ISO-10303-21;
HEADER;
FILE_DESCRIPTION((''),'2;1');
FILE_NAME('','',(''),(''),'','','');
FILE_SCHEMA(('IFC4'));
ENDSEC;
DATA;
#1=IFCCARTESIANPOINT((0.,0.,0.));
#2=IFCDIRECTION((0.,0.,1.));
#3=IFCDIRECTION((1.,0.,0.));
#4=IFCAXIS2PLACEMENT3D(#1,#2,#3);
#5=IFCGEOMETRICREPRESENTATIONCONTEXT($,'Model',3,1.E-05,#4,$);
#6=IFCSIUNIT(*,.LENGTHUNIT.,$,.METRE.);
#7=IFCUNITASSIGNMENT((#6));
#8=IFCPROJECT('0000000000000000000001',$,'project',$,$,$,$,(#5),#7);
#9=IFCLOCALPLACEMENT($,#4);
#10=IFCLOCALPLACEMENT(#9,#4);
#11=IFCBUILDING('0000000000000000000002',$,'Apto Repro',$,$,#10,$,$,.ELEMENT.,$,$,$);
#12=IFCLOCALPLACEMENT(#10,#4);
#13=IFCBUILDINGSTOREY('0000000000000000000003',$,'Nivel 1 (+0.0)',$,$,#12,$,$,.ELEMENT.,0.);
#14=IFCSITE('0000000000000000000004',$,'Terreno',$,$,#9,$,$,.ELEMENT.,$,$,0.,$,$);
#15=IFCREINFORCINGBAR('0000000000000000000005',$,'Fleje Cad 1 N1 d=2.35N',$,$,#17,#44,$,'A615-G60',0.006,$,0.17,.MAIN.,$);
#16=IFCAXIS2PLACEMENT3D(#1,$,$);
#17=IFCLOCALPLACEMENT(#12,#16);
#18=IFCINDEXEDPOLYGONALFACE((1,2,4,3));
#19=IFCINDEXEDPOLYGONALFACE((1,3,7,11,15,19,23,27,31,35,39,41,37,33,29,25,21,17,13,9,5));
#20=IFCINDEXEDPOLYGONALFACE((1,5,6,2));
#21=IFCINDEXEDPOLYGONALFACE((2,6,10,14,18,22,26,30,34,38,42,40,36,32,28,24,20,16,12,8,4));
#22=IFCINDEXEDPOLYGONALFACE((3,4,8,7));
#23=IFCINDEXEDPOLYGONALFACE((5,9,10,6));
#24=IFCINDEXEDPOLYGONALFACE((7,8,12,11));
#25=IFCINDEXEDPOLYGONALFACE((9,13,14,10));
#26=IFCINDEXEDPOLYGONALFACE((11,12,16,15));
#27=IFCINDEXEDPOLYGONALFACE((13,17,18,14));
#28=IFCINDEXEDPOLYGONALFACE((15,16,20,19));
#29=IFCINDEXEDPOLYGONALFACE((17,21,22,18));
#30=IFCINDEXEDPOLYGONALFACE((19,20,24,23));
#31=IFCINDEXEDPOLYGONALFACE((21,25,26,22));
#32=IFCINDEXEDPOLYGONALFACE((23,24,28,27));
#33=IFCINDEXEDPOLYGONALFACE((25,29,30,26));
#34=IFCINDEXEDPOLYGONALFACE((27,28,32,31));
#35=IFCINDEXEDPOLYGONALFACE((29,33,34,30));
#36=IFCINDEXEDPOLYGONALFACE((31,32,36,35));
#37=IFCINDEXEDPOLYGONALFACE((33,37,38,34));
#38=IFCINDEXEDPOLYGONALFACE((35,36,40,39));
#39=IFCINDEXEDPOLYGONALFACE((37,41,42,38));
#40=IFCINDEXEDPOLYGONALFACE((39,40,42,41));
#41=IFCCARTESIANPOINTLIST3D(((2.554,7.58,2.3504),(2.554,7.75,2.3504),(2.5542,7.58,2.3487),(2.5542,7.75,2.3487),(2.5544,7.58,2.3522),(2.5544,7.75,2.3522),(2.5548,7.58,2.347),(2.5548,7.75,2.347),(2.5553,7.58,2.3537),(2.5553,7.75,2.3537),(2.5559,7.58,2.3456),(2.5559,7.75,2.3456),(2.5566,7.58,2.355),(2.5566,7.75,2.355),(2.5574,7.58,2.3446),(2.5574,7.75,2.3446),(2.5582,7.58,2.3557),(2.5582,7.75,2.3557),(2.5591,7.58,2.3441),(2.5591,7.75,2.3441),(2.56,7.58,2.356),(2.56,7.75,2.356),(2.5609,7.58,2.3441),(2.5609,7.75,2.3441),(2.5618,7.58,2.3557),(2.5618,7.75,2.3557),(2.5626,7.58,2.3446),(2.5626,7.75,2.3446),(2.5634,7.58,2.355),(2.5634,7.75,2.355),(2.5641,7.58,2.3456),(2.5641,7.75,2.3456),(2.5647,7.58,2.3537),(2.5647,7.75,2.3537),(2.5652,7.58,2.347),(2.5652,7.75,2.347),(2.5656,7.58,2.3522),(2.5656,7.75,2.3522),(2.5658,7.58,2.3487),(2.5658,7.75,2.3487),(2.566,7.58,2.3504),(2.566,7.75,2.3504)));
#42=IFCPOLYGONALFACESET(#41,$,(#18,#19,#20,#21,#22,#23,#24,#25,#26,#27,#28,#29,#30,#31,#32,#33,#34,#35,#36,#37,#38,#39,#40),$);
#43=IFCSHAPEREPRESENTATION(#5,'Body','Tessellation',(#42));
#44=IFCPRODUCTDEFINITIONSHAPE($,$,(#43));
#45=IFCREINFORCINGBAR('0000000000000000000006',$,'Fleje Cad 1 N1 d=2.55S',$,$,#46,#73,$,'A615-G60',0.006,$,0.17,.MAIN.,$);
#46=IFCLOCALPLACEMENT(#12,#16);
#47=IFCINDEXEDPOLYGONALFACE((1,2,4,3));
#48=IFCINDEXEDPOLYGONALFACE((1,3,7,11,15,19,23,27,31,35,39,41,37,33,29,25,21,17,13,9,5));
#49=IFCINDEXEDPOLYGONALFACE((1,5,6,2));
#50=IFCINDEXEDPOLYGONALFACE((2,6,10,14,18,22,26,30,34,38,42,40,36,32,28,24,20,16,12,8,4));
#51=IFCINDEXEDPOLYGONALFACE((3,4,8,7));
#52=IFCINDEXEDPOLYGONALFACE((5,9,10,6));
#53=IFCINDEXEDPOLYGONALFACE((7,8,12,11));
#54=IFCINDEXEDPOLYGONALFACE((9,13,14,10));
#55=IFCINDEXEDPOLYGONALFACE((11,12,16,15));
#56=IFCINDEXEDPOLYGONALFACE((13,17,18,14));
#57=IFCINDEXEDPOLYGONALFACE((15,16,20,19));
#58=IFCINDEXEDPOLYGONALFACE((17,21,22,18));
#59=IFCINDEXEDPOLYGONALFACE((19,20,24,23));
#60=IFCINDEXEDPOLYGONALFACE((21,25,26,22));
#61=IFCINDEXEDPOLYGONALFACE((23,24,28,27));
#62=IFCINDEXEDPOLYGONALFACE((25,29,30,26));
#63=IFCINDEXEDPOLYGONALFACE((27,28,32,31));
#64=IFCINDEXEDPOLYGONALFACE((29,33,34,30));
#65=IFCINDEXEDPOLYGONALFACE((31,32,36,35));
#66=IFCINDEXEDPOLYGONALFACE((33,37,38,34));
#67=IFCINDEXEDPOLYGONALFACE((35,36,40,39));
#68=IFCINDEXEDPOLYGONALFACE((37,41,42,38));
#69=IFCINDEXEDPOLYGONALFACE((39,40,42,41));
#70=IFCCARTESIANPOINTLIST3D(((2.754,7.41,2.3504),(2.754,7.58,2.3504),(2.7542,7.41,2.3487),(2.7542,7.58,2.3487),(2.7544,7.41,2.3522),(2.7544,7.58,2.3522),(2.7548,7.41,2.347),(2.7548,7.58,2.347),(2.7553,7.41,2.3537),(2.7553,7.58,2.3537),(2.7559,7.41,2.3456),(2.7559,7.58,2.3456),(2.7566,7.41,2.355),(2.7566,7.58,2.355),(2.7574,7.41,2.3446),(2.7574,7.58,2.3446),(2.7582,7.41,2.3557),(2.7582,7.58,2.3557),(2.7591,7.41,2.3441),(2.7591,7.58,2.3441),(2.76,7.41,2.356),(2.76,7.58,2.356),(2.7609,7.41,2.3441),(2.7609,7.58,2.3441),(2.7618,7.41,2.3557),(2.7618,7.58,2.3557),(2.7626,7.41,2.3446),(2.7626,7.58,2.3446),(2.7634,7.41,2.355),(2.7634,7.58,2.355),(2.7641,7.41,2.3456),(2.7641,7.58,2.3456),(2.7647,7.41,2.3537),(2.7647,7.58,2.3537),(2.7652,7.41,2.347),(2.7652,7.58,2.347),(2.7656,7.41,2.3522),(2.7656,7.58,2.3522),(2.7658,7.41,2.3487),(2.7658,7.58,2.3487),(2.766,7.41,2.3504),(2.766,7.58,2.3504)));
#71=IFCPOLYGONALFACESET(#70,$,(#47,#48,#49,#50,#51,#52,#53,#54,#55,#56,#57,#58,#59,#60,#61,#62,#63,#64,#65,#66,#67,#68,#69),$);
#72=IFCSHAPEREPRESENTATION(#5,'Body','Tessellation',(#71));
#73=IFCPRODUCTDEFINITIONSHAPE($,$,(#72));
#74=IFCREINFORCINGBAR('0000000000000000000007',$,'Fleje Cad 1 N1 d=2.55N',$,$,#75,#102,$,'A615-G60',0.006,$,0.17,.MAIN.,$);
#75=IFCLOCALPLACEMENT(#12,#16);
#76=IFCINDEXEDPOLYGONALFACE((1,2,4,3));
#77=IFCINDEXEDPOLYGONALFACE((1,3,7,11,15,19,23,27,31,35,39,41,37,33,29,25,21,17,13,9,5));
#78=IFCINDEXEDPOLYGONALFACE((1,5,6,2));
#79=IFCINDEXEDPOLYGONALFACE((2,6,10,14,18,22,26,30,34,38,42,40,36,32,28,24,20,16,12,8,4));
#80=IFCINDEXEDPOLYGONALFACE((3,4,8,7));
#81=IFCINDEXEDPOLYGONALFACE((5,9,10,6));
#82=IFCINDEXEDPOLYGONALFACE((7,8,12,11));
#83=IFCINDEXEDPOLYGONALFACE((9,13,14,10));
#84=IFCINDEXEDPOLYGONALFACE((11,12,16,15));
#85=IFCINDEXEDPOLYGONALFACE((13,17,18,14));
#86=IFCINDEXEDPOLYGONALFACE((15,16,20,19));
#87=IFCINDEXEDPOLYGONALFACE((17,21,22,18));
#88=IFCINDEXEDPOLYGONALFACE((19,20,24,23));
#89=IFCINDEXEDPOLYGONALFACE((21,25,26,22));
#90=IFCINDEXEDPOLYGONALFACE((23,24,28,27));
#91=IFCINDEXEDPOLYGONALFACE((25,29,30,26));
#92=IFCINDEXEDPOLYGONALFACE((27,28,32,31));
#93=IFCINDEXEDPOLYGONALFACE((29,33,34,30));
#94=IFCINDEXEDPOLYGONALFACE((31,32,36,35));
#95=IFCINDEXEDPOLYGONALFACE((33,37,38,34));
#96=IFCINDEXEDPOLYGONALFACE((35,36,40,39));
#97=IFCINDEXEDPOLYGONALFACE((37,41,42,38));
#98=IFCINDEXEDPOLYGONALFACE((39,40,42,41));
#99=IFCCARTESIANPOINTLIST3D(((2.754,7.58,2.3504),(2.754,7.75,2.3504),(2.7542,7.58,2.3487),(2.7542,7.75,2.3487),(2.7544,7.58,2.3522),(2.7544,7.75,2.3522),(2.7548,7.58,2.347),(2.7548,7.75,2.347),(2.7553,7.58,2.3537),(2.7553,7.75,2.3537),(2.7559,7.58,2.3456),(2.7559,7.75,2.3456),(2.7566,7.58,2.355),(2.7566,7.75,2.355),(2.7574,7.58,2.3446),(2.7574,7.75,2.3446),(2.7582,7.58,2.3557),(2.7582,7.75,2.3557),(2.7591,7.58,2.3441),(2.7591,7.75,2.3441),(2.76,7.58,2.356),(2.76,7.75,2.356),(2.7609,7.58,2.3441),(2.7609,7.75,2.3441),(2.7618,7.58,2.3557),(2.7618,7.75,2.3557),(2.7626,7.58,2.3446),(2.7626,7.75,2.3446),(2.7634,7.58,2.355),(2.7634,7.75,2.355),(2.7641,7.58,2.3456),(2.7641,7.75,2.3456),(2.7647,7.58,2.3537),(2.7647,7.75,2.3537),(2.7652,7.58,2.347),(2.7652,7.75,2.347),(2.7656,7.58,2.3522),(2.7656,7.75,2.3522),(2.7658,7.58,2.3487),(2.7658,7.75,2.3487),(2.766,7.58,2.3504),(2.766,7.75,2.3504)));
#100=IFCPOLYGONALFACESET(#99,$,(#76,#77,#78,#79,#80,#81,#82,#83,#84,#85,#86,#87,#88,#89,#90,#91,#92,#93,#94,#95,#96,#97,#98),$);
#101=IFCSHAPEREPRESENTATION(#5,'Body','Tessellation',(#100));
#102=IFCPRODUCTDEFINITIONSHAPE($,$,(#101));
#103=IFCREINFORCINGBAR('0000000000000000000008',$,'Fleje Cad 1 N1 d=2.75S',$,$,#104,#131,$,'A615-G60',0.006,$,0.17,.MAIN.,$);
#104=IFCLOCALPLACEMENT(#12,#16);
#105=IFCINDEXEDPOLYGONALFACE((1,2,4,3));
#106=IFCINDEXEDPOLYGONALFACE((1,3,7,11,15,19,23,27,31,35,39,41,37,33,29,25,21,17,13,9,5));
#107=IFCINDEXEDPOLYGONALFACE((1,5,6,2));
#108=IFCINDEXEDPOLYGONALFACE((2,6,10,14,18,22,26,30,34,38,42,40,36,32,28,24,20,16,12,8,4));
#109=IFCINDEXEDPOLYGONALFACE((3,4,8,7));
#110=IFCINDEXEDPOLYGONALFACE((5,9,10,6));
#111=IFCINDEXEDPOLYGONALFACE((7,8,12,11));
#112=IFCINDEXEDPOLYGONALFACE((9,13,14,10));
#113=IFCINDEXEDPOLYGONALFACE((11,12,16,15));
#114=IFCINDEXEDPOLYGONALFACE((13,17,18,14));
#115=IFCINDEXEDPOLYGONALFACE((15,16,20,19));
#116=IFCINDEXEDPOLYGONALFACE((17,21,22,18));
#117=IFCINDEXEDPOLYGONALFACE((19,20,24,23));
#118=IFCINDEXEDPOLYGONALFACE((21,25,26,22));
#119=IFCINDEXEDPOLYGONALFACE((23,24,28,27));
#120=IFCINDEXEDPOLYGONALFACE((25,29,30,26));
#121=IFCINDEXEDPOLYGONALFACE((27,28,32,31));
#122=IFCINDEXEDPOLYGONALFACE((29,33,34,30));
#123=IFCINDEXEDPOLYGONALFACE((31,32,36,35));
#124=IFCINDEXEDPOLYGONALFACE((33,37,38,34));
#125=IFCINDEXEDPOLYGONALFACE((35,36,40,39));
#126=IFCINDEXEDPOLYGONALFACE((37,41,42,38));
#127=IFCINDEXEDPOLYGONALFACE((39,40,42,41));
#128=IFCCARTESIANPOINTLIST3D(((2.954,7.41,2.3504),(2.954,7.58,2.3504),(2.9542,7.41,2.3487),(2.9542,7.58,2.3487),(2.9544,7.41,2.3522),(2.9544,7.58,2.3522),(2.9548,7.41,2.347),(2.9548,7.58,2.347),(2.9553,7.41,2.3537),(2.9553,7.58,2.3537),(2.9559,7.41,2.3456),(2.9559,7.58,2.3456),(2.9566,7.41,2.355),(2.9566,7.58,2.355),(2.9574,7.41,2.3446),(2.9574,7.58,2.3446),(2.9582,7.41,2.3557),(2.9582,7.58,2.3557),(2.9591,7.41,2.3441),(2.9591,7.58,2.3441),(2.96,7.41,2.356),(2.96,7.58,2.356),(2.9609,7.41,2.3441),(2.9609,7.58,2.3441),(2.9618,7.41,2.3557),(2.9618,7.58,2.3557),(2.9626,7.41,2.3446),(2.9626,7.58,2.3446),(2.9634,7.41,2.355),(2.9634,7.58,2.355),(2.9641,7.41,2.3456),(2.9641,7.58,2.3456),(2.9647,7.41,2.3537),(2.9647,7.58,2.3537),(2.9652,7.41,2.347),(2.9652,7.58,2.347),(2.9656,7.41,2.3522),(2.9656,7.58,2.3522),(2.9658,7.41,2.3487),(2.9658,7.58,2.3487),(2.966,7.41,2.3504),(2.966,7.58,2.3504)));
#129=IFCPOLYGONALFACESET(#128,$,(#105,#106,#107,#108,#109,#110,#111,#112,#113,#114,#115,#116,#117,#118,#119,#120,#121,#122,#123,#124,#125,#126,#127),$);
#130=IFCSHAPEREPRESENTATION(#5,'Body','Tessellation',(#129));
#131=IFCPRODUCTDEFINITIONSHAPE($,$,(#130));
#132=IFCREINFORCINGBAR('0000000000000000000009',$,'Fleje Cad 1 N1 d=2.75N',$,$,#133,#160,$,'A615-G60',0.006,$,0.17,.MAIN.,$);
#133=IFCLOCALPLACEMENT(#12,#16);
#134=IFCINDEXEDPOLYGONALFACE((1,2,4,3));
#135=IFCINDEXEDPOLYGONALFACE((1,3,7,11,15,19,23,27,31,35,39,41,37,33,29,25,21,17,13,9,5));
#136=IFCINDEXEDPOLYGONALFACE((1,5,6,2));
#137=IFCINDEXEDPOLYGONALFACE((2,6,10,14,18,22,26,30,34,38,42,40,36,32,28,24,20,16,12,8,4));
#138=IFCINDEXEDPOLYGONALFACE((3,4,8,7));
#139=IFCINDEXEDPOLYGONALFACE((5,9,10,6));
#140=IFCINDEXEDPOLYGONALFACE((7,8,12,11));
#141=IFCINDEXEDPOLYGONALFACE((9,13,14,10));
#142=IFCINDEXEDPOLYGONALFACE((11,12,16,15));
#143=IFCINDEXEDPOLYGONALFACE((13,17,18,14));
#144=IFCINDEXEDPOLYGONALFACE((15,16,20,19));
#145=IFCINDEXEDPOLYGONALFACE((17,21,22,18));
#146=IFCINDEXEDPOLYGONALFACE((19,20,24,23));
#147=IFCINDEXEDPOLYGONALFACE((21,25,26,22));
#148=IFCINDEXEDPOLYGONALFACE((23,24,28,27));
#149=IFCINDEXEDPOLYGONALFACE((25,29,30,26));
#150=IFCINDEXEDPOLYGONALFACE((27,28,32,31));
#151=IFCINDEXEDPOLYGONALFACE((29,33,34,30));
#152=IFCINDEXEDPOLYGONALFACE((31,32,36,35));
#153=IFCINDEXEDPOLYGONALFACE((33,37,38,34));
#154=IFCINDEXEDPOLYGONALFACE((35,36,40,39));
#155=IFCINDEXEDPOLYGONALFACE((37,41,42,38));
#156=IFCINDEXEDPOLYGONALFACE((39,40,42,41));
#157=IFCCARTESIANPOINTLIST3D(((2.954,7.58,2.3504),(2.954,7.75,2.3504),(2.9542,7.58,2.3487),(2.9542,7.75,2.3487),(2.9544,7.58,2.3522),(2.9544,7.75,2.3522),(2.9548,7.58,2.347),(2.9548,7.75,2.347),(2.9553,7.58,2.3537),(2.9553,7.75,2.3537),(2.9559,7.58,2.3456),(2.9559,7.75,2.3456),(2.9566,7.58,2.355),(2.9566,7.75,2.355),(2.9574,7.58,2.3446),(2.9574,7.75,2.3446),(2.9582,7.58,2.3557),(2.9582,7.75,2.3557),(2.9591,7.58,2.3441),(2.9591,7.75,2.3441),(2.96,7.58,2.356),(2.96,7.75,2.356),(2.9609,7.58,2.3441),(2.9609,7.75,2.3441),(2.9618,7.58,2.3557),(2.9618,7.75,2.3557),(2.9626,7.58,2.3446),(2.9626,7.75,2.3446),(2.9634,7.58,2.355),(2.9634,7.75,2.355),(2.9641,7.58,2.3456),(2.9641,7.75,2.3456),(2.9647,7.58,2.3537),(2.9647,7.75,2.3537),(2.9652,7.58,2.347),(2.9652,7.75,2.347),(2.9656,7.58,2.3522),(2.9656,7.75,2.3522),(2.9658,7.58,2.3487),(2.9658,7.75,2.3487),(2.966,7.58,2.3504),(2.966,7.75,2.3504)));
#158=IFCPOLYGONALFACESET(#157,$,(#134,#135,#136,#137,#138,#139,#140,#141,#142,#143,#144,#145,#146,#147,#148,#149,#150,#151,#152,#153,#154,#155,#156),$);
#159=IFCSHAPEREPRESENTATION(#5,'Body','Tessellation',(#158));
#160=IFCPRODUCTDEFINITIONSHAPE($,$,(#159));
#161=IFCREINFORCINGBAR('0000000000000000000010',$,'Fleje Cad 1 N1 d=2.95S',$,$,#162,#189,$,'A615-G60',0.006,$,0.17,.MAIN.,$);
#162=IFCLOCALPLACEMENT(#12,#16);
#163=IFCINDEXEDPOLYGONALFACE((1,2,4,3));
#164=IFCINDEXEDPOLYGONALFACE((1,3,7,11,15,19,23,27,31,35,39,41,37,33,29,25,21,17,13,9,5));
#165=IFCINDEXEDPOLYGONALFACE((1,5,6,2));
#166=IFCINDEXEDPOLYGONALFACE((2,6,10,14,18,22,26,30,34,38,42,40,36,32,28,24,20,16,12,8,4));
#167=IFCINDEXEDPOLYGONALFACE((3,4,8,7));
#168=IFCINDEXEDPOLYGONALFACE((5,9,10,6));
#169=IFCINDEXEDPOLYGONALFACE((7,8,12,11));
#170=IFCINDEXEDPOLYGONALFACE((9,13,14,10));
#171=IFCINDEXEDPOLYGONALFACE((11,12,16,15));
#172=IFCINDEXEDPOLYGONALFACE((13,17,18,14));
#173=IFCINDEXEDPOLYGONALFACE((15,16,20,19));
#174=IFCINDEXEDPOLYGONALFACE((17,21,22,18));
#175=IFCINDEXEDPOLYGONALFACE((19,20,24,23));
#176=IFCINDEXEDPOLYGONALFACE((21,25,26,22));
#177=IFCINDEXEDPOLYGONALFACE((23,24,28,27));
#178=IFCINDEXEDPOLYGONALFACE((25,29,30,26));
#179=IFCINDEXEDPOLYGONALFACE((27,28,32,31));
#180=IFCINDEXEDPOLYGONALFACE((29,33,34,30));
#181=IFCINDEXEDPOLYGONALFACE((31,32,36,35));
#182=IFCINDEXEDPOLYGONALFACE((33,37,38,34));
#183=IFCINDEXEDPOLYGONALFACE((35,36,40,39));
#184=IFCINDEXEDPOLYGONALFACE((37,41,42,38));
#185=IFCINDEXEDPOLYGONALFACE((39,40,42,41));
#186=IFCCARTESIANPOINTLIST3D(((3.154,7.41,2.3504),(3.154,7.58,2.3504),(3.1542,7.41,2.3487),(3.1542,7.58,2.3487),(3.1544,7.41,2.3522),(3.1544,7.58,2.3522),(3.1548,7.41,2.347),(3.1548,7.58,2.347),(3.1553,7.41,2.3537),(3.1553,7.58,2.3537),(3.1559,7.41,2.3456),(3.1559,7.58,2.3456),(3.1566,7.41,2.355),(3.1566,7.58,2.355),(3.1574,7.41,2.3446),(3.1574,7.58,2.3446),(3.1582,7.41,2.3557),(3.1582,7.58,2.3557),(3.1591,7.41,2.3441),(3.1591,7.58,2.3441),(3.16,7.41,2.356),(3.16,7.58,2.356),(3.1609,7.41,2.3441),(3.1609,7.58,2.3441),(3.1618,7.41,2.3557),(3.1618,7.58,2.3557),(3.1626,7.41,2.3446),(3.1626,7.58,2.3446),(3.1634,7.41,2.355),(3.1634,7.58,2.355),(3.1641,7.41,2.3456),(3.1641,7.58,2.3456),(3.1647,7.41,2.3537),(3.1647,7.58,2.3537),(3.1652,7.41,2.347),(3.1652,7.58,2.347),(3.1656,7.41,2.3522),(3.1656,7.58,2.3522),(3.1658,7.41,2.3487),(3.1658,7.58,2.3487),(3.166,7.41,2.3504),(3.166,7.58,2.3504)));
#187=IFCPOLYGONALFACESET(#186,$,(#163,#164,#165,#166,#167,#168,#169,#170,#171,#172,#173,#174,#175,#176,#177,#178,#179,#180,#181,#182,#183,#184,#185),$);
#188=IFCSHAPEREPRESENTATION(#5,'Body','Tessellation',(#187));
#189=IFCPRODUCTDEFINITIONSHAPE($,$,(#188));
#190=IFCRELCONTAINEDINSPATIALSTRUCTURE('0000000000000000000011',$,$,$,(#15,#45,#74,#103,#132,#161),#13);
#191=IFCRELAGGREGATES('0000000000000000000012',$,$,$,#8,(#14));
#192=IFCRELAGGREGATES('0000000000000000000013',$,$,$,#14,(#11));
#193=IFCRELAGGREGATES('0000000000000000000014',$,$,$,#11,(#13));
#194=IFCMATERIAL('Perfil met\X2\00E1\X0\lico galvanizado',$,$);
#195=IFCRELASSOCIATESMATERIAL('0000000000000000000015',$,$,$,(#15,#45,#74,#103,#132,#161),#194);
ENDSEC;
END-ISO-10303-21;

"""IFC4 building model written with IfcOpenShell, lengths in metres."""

from ifc_helpers import new_model, si_unit, frame, origin_with_axes, origin_2d_with_axis, place, context, project, spatial, circle, extrude, material, element, save


model = new_model("IFC4")

# Units and contexts
model_context = context("Model", 3, precision=1e-05, world=origin_with_axes())
ifc_project = project(units=[si_unit("LENGTHUNIT", "METRE")], contexts=[model_context])

# Site, building, storey
site_placement = place(None, origin_with_axes())
site = spatial("IfcSite", under=ifc_project, at=site_placement, Name="Terreno", CompositionType="ELEMENT", RefElevation=0.0)
building_placement = place(site_placement, origin_with_axes())
building = spatial("IfcBuilding", under=site, at=building_placement, Name="Apto Repro", CompositionType="ELEMENT")
storey_placement = place(building_placement, origin_with_axes())
storey = spatial("IfcBuildingStorey", under=building, at=storey_placement, Name="Nivel 1 (+0.0)", CompositionType="ELEMENT", Elevation=0.0)

# Reinforcing bars
ifc_material = material(Name="Perfil metálico galvanizado")
reinforcing_bar_1_placement = place(storey_placement, origin_with_axes())
element("IfcReinforcingBar", 1, at=reinforcing_bar_1_placement, inside=storey, material=ifc_material, Name="Fleje Cad 1 N1 d=2.35N", SteelGrade="A615-G60", BarLength=0.17, NominalDiameter=0.006, PredefinedType="MAIN", context=model_context, shape_type="SweptSolid", body=[
    extrude(circle(Radius=0.006, at=origin_2d_with_axis()), frame((2.56, 7.58, 2.35), z_axis=(0.0, 1.0, 0.0), x_axis=(0.0, 0.0, 1.0)), (0.0, 0.0, 1.0), 0.17),
])
reinforcing_bar_2_placement = place(storey_placement, origin_with_axes())
element("IfcReinforcingBar", 2, at=reinforcing_bar_2_placement, inside=storey, material=ifc_material, Name="Fleje Cad 1 N1 d=2.55S", SteelGrade="A615-G60", BarLength=0.17, NominalDiameter=0.006, PredefinedType="MAIN", context=model_context, shape_type="SweptSolid", body=[
    extrude(circle(Radius=0.006, at=origin_2d_with_axis()), frame((2.76, 7.41, 2.35), z_axis=(0.0, 1.0, 0.0), x_axis=(0.0, 0.0, 1.0)), (0.0, 0.0, 1.0), 0.17),
])
reinforcing_bar_3_placement = place(storey_placement, origin_with_axes())
element("IfcReinforcingBar", 3, at=reinforcing_bar_3_placement, inside=storey, material=ifc_material, Name="Fleje Cad 1 N1 d=2.55N", SteelGrade="A615-G60", BarLength=0.17, NominalDiameter=0.006, PredefinedType="MAIN", context=model_context, shape_type="SweptSolid", body=[
    extrude(circle(Radius=0.006, at=origin_2d_with_axis()), frame((2.76, 7.58, 2.35), z_axis=(0.0, 1.0, 0.0), x_axis=(0.0, 0.0, 1.0)), (0.0, 0.0, 1.0), 0.17),
])
reinforcing_bar_4_placement = place(storey_placement, origin_with_axes())
element("IfcReinforcingBar", 4, at=reinforcing_bar_4_placement, inside=storey, material=ifc_material, Name="Fleje Cad 1 N1 d=2.75S", SteelGrade="A615-G60", BarLength=0.17, NominalDiameter=0.006, PredefinedType="MAIN", context=model_context, shape_type="SweptSolid", body=[
    extrude(circle(Radius=0.006, at=origin_2d_with_axis()), frame((2.96, 7.41, 2.35), z_axis=(0.0, 1.0, 0.0), x_axis=(0.0, 0.0, 1.0)), (0.0, 0.0, 1.0), 0.17),
])
reinforcing_bar_5_placement = place(storey_placement, origin_with_axes())
element("IfcReinforcingBar", 5, at=reinforcing_bar_5_placement, inside=storey, material=ifc_material, Name="Fleje Cad 1 N1 d=2.75N", SteelGrade="A615-G60", BarLength=0.17, NominalDiameter=0.006, PredefinedType="MAIN", context=model_context, shape_type="SweptSolid", body=[
    extrude(circle(Radius=0.006, at=origin_2d_with_axis()), frame((2.96, 7.58, 2.35), z_axis=(0.0, 1.0, 0.0), x_axis=(0.0, 0.0, 1.0)), (0.0, 0.0, 1.0), 0.17),
])
reinforcing_bar_6_placement = place(storey_placement, origin_with_axes())
element("IfcReinforcingBar", 6, at=reinforcing_bar_6_placement, inside=storey, material=ifc_material, Name="Fleje Cad 1 N1 d=2.95S", SteelGrade="A615-G60", BarLength=0.17, NominalDiameter=0.006, PredefinedType="MAIN", context=model_context, shape_type="SweptSolid", body=[
    extrude(circle(Radius=0.006, at=origin_2d_with_axis()), frame((3.16, 7.41, 2.35), z_axis=(0.0, 1.0, 0.0), x_axis=(0.0, 0.0, 1.0)), (0.0, 0.0, 1.0), 0.17),
])

save(model, "model.ifc")
